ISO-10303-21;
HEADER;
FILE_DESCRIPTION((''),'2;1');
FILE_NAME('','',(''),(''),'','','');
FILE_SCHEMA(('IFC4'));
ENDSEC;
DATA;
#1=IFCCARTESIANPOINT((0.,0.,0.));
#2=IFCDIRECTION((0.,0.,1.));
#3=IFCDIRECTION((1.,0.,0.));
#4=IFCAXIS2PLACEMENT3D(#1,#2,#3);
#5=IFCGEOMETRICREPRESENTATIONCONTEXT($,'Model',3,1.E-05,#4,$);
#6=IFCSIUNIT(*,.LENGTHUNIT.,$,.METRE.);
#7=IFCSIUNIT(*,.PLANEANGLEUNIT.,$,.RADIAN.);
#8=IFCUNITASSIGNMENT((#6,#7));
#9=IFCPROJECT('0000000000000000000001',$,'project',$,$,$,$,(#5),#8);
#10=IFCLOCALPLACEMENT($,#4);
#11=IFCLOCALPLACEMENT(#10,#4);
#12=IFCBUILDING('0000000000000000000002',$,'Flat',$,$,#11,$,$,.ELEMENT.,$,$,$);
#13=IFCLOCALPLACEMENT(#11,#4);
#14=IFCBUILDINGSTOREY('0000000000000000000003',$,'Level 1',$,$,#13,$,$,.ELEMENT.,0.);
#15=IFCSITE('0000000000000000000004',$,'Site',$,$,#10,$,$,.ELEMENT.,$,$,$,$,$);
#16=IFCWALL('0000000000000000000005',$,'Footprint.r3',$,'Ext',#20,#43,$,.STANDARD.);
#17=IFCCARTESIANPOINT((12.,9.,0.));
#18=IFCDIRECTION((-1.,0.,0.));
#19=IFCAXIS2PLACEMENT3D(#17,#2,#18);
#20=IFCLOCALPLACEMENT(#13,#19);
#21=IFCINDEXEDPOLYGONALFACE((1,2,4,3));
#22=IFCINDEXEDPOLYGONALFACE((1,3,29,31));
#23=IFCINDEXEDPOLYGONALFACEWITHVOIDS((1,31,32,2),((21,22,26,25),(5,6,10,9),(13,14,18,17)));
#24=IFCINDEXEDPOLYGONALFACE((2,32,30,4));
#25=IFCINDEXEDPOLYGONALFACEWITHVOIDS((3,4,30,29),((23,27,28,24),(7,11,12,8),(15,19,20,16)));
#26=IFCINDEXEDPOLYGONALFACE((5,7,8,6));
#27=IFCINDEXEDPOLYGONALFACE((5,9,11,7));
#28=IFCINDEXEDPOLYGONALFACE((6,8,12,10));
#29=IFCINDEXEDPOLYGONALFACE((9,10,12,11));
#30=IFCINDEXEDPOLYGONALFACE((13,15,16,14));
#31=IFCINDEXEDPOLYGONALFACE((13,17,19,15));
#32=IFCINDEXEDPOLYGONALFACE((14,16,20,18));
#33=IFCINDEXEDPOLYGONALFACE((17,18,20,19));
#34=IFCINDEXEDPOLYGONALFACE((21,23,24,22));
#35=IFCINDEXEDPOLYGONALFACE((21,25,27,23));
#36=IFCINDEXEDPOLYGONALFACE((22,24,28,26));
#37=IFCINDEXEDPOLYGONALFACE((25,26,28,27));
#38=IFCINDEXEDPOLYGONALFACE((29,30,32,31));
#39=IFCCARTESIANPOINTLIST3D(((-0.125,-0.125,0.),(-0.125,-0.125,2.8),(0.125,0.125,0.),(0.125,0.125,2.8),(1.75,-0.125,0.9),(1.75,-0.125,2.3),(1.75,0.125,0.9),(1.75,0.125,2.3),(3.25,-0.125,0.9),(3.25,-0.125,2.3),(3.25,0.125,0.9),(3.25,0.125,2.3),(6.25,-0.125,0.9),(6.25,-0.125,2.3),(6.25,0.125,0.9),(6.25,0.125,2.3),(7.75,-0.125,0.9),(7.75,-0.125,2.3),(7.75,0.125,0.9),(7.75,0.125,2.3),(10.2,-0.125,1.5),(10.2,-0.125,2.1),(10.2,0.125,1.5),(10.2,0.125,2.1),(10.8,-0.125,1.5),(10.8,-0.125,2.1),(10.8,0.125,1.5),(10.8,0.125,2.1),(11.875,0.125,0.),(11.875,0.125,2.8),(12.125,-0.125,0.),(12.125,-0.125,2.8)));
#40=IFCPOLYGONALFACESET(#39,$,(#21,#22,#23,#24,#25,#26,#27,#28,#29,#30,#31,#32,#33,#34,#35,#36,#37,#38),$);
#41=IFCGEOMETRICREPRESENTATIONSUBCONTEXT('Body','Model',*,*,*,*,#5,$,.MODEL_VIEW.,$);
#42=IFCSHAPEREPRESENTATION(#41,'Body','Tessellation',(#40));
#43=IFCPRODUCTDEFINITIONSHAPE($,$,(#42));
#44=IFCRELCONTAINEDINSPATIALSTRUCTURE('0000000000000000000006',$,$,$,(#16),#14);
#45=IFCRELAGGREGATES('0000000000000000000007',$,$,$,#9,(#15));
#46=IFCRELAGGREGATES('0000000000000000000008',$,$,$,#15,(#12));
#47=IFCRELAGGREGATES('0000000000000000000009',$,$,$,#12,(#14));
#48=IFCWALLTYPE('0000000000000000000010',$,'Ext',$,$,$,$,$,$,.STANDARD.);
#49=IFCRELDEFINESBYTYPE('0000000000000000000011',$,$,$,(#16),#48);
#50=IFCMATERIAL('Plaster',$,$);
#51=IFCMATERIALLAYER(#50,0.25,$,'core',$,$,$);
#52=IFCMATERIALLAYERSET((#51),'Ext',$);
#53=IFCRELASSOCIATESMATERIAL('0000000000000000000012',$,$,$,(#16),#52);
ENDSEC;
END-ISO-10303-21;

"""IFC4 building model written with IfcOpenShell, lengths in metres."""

from ifc_helpers import new_model, si_unit, frame, origin_with_axes, origin_2d_with_axis, place, context, subcontext, project, spatial, polyline, rectangle, outline, extrude, material, layer, layer_set, layer_usage, type_object, element, save


model = new_model("IFC4")

# Units and contexts
model_context = context("Model", 3, precision=1e-05, world=origin_with_axes())
body_context = subcontext(model_context, "Body", "Model", "MODEL_VIEW")
ifc_project = project(units=[si_unit("LENGTHUNIT", "METRE"), si_unit("PLANEANGLEUNIT", "RADIAN")], contexts=[model_context])

# Site, building, storey
site_placement = place(None, origin_with_axes())
site = spatial("IfcSite", under=ifc_project, at=site_placement, Name="Site", CompositionType="ELEMENT")
building_placement = place(site_placement, origin_with_axes())
building = spatial("IfcBuilding", under=site, at=building_placement, Name="Flat", CompositionType="ELEMENT")
storey_placement = place(building_placement, origin_with_axes())
storey = spatial("IfcBuildingStorey", under=building, at=storey_placement, Name="Level 1", CompositionType="ELEMENT", Elevation=0.0)

# Shared definitions
ifc_material_1 = material(Name="Plaster")
ifc_layer_1 = layer(ifc_material_1, 0.25, Name="core")
ifc_layer_set_1 = layer_set([ifc_layer_1], Name="Ext")
wall_type_1 = type_object("IfcWallType", Name="Ext", PredefinedType="STANDARD")

# Wall, openings
ifc_layer_usage_1 = layer_usage(ifc_layer_set_1, "AXIS2", "POSITIVE", -0.125)
wall_1_placement = place(storey_placement, frame((12.0, 9.0, 0.0), z_axis=(0.0, 0.0, 1.0), x_axis=(-1.0, 0.0, 0.0)))
wall_1 = element("IfcWall", 1, at=wall_1_placement, inside=storey, type_object=wall_type_1, material=ifc_layer_usage_1, Name="Footprint.r3", ObjectType="Ext", PredefinedType="STANDARD", context=body_context, shape_type="SweptSolid", body=[
    extrude(outline(polyline([(-0.125, -0.125), (12.125, -0.125), (12.0, 0.0), (11.875, 0.125), (0.125, 0.125), (0.0, 0.0), (-0.125, -0.125)])), origin_with_axes(), (0.0, 0.0, 1.0), 2.8),
])
opening_1_placement = place(wall_1_placement, frame((2.5, -0.135, 1.6), z_axis=(0.0, 1.0, 0.0), x_axis=(1.0, 0.0, 0.0)))
element("IfcOpeningElement", 2, at=opening_1_placement, cuts=wall_1, PredefinedType="OPENING", context=body_context, shape_type="SweptSolid", body=[
    extrude(rectangle(XDim=1.5, YDim=1.4, at=origin_2d_with_axis()), origin_with_axes(), (0.0, 0.0, 1.0), 0.27),
])
opening_2_placement = place(wall_1_placement, frame((7.0, -0.135, 1.6), z_axis=(0.0, 1.0, 0.0), x_axis=(1.0, 0.0, 0.0)))
element("IfcOpeningElement", 3, at=opening_2_placement, cuts=wall_1, PredefinedType="OPENING", context=body_context, shape_type="SweptSolid", body=[
    extrude(rectangle(XDim=1.5, YDim=1.4, at=origin_2d_with_axis()), origin_with_axes(), (0.0, 0.0, 1.0), 0.27),
])
opening_3_placement = place(wall_1_placement, frame((10.5, -0.135, 1.8), z_axis=(0.0, 1.0, 0.0), x_axis=(1.0, 0.0, 0.0)))
element("IfcOpeningElement", 4, at=opening_3_placement, cuts=wall_1, PredefinedType="OPENING", context=body_context, shape_type="SweptSolid", body=[
    extrude(rectangle(XDim=0.6, YDim=0.6, at=origin_2d_with_axis()), origin_with_axes(), (0.0, 0.0, 1.0), 0.27),
])

save(model, "model.ifc")
